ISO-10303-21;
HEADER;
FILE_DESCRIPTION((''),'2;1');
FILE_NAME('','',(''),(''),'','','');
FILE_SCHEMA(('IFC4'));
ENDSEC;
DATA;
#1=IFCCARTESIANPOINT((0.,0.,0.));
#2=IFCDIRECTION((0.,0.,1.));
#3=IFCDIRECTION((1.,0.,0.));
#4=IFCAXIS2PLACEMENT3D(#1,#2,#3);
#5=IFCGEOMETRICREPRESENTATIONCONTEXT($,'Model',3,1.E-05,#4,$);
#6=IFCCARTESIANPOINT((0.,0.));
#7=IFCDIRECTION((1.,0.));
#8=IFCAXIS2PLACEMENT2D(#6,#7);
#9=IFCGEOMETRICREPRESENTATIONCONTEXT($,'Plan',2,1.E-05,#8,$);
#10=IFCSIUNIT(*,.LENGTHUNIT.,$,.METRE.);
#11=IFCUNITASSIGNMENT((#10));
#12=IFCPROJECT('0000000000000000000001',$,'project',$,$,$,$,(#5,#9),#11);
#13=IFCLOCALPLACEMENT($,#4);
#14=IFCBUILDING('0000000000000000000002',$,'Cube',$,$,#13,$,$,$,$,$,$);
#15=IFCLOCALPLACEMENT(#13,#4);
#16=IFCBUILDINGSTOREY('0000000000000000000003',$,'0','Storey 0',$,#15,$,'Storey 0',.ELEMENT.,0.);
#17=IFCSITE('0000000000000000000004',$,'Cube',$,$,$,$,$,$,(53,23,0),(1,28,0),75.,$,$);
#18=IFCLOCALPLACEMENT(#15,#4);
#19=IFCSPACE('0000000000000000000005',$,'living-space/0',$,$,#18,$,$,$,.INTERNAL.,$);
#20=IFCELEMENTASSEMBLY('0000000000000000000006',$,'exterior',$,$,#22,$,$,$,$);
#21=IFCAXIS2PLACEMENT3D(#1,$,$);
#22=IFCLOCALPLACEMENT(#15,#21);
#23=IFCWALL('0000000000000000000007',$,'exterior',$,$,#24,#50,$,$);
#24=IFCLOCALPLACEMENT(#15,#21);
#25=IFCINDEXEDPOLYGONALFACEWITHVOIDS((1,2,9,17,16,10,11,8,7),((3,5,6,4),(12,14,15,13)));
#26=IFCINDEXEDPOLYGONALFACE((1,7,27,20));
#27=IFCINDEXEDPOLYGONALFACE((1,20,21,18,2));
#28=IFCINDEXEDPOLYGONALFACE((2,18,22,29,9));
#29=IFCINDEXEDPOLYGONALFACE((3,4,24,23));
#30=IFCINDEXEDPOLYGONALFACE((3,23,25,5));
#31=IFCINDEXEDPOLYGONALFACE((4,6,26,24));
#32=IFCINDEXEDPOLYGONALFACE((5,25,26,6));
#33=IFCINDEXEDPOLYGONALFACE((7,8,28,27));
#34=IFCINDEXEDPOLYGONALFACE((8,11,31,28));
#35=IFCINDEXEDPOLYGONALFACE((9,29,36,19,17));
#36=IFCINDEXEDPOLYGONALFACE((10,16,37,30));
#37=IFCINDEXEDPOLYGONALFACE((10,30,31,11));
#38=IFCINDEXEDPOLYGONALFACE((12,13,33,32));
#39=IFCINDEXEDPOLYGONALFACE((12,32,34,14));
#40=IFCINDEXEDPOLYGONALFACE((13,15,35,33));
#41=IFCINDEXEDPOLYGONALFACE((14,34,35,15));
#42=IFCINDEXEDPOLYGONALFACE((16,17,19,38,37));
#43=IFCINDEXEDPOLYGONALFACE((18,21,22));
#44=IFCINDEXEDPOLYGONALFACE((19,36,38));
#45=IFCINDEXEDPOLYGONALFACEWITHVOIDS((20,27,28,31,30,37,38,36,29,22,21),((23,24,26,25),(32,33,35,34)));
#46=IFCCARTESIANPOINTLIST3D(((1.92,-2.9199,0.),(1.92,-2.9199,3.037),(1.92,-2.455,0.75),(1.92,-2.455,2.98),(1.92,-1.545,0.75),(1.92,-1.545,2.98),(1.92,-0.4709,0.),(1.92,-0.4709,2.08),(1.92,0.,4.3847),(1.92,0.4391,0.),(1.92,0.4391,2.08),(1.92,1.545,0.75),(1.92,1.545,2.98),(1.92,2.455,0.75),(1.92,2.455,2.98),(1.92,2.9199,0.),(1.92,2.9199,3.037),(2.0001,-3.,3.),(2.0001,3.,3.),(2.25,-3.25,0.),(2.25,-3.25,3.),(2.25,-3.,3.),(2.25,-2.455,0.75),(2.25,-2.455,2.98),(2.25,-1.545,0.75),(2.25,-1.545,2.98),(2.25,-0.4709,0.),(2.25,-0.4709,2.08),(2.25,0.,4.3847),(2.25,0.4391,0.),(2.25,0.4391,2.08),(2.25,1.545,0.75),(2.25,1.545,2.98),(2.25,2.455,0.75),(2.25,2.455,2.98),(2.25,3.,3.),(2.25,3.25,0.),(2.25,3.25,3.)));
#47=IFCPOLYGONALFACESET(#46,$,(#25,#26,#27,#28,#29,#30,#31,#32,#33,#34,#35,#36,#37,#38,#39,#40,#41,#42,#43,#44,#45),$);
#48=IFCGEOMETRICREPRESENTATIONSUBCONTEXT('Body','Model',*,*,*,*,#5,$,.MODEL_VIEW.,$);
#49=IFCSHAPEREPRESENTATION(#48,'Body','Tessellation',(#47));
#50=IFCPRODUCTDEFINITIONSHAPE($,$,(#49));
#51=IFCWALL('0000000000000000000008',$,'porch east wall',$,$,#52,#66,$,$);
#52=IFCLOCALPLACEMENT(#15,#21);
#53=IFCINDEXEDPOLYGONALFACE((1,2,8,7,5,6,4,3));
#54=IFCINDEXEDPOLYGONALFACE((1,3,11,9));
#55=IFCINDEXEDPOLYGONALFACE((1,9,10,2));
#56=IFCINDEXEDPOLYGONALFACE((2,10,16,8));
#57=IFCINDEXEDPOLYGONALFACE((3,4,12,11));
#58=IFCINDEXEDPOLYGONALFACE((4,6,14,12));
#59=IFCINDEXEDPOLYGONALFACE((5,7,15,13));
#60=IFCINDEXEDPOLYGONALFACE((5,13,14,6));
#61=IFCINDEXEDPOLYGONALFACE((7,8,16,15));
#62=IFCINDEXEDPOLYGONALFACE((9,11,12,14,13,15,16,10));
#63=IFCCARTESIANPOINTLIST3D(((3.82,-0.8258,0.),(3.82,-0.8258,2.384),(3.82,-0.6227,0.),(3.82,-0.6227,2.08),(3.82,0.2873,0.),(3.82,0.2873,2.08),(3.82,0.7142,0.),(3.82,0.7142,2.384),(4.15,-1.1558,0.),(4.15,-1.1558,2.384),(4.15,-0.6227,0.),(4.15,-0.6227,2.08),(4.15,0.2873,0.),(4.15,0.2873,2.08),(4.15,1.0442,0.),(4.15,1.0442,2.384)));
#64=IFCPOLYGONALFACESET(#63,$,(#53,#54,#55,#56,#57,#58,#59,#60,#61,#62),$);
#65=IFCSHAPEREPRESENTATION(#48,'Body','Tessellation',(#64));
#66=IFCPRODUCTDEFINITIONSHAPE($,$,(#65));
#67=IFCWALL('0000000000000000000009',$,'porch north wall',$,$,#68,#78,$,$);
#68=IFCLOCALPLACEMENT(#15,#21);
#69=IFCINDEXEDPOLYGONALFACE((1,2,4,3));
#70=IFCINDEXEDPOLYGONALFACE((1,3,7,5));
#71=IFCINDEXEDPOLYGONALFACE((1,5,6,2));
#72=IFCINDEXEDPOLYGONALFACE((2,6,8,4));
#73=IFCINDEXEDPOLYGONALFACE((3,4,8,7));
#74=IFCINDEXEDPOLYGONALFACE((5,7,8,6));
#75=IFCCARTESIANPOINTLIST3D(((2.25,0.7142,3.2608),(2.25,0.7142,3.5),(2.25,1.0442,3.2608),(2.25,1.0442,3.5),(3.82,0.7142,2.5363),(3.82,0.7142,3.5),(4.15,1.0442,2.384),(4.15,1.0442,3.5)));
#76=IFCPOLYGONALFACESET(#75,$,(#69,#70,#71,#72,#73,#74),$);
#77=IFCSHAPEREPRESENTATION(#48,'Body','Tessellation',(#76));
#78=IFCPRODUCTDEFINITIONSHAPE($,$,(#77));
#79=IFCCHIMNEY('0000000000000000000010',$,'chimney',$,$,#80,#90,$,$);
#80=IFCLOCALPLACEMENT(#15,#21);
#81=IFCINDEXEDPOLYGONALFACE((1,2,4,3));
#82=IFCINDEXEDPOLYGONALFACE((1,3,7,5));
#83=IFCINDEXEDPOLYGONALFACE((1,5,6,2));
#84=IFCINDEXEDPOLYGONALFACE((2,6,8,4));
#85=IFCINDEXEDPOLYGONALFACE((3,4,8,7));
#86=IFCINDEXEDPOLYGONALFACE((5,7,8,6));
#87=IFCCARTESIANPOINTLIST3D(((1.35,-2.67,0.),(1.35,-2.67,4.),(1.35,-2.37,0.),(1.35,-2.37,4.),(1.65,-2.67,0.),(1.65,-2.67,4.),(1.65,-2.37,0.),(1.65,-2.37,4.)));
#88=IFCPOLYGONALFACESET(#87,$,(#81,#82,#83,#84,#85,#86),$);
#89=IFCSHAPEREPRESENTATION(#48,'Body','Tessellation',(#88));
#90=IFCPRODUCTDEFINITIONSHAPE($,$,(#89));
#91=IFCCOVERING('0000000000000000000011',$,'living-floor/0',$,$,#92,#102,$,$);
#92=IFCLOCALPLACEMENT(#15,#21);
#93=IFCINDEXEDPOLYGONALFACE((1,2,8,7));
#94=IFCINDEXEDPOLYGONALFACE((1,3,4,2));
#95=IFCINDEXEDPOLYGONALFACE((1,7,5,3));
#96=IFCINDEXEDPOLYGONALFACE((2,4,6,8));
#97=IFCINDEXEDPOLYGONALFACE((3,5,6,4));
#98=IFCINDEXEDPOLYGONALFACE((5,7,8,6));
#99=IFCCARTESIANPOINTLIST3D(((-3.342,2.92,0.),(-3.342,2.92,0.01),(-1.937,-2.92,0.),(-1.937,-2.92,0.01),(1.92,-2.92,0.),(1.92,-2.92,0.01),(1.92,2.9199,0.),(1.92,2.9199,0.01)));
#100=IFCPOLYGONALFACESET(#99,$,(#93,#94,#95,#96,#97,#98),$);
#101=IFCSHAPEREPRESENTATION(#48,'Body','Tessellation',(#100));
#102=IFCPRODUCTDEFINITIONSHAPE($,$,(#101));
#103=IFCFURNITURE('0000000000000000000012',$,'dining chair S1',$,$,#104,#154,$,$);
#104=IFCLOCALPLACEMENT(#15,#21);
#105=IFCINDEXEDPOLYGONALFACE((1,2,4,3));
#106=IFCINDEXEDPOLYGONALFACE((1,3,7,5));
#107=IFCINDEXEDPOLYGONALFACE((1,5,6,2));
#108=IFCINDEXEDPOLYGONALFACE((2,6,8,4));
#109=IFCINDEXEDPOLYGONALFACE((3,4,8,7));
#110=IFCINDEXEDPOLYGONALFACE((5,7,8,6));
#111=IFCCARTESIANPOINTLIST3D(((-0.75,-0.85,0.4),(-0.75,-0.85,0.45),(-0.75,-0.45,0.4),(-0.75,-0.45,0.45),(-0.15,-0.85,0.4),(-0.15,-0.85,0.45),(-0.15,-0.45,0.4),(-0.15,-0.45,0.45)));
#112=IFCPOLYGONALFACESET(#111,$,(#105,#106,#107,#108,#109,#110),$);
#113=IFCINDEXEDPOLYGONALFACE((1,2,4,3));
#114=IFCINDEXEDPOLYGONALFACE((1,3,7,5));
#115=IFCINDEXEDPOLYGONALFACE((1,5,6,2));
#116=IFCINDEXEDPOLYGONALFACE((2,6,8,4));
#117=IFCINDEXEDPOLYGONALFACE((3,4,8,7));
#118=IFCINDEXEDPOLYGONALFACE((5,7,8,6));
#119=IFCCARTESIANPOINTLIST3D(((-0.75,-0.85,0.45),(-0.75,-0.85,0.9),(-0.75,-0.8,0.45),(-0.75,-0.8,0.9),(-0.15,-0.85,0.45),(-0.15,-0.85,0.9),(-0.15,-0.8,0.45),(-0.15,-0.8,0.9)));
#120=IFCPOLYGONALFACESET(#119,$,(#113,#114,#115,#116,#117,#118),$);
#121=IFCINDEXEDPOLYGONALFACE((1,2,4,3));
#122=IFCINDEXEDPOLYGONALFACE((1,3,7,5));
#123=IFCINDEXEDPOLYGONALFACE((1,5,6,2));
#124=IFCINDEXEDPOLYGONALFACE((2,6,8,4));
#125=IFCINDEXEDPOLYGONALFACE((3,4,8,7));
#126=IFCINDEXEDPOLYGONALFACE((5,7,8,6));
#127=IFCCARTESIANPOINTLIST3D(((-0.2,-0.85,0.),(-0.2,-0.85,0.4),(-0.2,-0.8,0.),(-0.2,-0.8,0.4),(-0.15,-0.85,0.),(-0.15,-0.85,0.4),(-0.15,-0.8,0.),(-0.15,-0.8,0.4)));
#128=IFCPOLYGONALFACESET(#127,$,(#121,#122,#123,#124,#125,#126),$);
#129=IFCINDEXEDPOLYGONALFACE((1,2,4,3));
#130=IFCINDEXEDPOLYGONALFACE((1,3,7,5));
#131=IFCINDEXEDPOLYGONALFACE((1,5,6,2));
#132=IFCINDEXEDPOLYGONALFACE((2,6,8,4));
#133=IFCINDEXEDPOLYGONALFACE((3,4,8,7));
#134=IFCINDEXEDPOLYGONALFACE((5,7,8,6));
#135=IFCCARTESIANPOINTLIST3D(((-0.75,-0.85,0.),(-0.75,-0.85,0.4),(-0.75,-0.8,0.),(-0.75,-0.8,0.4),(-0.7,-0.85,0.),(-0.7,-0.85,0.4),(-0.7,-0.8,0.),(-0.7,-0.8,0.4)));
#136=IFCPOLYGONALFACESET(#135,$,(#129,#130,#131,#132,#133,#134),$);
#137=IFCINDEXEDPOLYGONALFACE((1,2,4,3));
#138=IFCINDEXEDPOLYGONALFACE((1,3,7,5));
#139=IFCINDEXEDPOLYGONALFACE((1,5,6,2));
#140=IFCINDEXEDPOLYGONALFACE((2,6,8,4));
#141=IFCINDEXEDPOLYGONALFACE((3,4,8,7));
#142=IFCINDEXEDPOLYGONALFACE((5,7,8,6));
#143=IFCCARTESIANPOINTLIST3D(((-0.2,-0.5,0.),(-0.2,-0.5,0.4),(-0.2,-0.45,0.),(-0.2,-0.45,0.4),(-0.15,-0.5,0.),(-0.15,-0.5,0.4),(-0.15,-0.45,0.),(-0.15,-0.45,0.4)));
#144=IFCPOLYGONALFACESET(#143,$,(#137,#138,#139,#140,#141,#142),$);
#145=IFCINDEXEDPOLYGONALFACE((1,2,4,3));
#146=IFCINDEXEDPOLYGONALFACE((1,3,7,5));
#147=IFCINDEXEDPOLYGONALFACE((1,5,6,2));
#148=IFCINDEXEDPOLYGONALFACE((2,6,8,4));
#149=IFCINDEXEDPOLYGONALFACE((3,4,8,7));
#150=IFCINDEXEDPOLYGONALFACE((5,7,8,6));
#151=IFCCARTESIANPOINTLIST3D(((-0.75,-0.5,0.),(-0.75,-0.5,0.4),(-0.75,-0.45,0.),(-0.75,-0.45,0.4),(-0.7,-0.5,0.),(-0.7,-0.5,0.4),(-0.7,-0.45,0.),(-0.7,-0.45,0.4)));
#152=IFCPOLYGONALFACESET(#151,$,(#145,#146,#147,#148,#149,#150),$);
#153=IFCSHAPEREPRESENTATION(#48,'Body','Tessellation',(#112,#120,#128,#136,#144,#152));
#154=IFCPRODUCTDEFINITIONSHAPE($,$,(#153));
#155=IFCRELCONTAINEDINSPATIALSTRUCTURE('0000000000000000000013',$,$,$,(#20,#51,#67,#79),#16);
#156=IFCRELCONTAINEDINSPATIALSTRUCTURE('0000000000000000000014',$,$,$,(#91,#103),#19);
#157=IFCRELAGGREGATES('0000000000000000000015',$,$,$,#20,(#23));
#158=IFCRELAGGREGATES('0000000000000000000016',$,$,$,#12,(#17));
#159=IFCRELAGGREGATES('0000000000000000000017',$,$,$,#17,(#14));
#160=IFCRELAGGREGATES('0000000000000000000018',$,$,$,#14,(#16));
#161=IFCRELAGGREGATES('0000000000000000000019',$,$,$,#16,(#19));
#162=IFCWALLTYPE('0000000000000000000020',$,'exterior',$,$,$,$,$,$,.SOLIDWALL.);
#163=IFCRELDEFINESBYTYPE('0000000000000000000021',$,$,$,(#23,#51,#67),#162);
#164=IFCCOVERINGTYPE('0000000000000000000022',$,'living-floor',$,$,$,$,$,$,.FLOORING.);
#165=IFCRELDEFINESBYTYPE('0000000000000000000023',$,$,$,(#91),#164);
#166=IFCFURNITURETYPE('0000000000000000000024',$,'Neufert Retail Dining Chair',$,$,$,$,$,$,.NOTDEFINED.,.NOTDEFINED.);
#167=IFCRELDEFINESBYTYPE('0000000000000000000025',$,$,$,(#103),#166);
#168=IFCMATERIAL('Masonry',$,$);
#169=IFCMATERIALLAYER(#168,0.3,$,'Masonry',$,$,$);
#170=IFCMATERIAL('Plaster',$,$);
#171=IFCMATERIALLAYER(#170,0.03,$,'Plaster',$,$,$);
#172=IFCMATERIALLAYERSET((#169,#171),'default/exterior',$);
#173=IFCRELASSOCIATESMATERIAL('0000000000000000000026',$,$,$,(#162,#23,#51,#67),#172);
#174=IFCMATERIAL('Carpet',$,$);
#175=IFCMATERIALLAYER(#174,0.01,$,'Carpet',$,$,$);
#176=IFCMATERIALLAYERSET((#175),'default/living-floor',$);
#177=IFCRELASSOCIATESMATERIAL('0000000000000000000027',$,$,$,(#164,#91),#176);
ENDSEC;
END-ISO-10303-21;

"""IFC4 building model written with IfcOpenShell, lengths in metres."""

from ifc_helpers import new_model, entity, si_unit, frame, origin, origin_with_axes, origin_2d_with_axis, place, context, subcontext, project, spatial, polyline, line, indexed_curve, outline, extrude, clip, halfspace, bounded_halfspace, shape, source, transform, mapped, material, layer, layer_set, layer_usage, type_object, type_shapes, element, aggregate, save


model = new_model("IFC4")

# Units and contexts
model_context = context("Model", 3, precision=1e-05, world=origin_with_axes())
plan_context = context("Plan", 2, precision=1e-05, world=origin_2d_with_axis())
body_context_1 = subcontext(model_context, "Body", "Model", "MODEL_VIEW")
body_context_2 = subcontext(plan_context, "Body", "Plan", "PLAN_VIEW")
ifc_project = project(units=[si_unit("LENGTHUNIT", "METRE")], contexts=[model_context, plan_context])

# Site, building, storey
site = spatial("IfcSite", under=ifc_project, Name="Cube", RefLatitude=(53, 23, 0), RefLongitude=(1, 28, 0), RefElevation=75.0)
building_placement = place(None, origin_with_axes())
building = spatial("IfcBuilding", under=site, at=building_placement, Name="Cube")
storey_placement = place(building_placement, origin_with_axes())
storey = spatial("IfcBuildingStorey", under=building, at=storey_placement, Name="0", Description="Storey 0", LongName="Storey 0", CompositionType="ELEMENT", Elevation=0.0)

# Element assembly, wall, openings
ifc_material_1 = material(Name="Masonry")
ifc_layer_1 = layer(ifc_material_1, 0.3, Name="Masonry")
ifc_material_2 = material(Name="Plaster")
ifc_layer_2 = layer(ifc_material_2, 0.03, Name="Plaster")
ifc_layer_set_1 = layer_set([ifc_layer_1, ifc_layer_2], Name="default/exterior")
wall_type = type_object("IfcWallType", Name="exterior", PredefinedType="SOLIDWALL", material=ifc_layer_set_1)
assembly_1_placement = place(storey_placement, frame((2.0, -3.0, 0.0), z_axis=(0.0, 0.0, 1.0), x_axis=(0.0, 1.0, 0.0)))
assembly_1 = element("IfcElementAssembly", 1, at=assembly_1_placement, inside=storey, Name="exterior")
ifc_layer_usage_1 = layer_usage(ifc_layer_set_1, "AXIS2", "POSITIVE", -0.25)
wall_1_placement = place(assembly_1_placement, origin_with_axes())
wall_1 = element("IfcWall", 2, at=wall_1_placement, type_object=wall_type, material=ifc_layer_usage_1, Name="exterior", context=body_context_1, shape_type="Clipping", body=[
    clip(clip(clip(clip(extrude(outline(polyline([(0.0801, 0.08), (-0.25, -0.25), (6.25, -0.25), (5.9199, 0.08), (0.0801, 0.08)])), origin(), (0.0, 0.0, 1.0), 4.385), bounded_halfspace(frame((6.0, 0.0, 3.0), z_axis=(0.419069, 0.0, 0.907954), x_axis=(0.0, -1.0, 0.0)), False, origin(), polyline([(6.0, -1.0), (3.0, -1.0), (3.0, 1.0), (6.0, 1.0), (6.0, -1.0)]))), bounded_halfspace(frame((6.0, 0.0, 3.0), z_axis=(0.0, 0.0, 1.0), x_axis=(0.0, 1.0, 0.0)), False, origin(), polyline([(6.0, 1.0), (7.0, 1.0), (7.0, -1.0), (6.0, -1.0), (6.0, 1.0)]))), bounded_halfspace(frame((3.0, 0.0, 4.3847), z_axis=(-0.419069, 0.0, 0.907954), x_axis=(0.0, -1.0, 0.0)), False, origin(), polyline([(3.0, -1.0), (0.0, -1.0), (0.0, 1.0), (3.0, 1.0), (3.0, -1.0)]))), bounded_halfspace(frame((0.0, 0.0, 3.0), z_axis=(0.0, 0.0, 1.0), x_axis=(0.0, -1.0, 0.0)), False, origin(), polyline([(0.0, -1.0), (-1.0, -1.0), (-1.0, 1.0), (0.0, 1.0), (0.0, -1.0)]))),
])
opening_1_placement = place(wall_1_placement, frame((0.545, -0.25, 0.75), z_axis=(0.0, 0.0, 1.0), x_axis=(1.0, 0.0, 0.0)))
element("IfcOpeningElement", 3, at=opening_1_placement, cuts=wall_1, PredefinedType="OPENING", context=body_context_1, shape_type="SweptSolid", body=[
    extrude(outline(polyline([(0.0, -0.02), (0.91, -0.02), (0.91, 0.35), (0.0, 0.35), (0.0, -0.02)])), origin(), (0.0, 0.0, 1.0), 2.23),
])
opening_2_placement = place(wall_1_placement, frame((4.545, -0.25, 0.75), z_axis=(0.0, 0.0, 1.0), x_axis=(1.0, 0.0, 0.0)))
element("IfcOpeningElement", 4, at=opening_2_placement, cuts=wall_1, PredefinedType="OPENING", context=body_context_1, shape_type="SweptSolid", body=[
    extrude(outline(polyline([(0.0, -0.02), (0.91, -0.02), (0.91, 0.35), (0.0, 0.35), (0.0, -0.02)])), origin(), (0.0, 0.0, 1.0), 2.23),
])
shared_shape_1 = source(origin_with_axes(), body_context_1, "Body", "SweptSolid", [
    extrude(outline(indexed_curve([(0.0, 0.0), (0.91, 0.0), (0.91, 2.08), (0.0, 2.08)], segments=[line(1, 2, 3, 4, 1)])), frame((0.0, -0.6, 0.0), z_axis=(0.0, -1.0, 0.0), x_axis=(1.0, 0.0, 0.0)), (0.0, 0.0, -1.0), 1.2),
])
opening_3_placement = place(wall_1_placement, frame((2.5291, -0.25, 0.0), z_axis=(0.0, 0.0, 1.0), x_axis=(1.0, 0.0, 0.0)))
element("IfcOpeningElement", 5, at=opening_3_placement, cuts=wall_1, PredefinedType="OPENING", context=body_context_1, shape_type="MappedRepresentation", body=[
    mapped(shared_shape_1, transform((0.0, 0.0, 0.0), x_axis=(1.0, 0.0, 0.0), y_axis=(0.0, 1.0, 0.0), z_axis=(0.0, 0.0, 1.0), scale=1.0)),
])
aggregate(assembly_1, [wall_1])

# Wall, opening
ifc_layer_usage_2 = layer_usage(ifc_layer_set_1, "AXIS2", "POSITIVE", 0.0)
wall_2_placement = place(storey_placement, frame((4.15, -1.1558, 0.0), z_axis=(0.0, 0.0, 1.0), x_axis=(0.0, 1.0, 0.0)))
wall_2 = element("IfcWall", 6, at=wall_2_placement, inside=storey, type_object=wall_type, material=ifc_layer_usage_2, Name="porch east wall", context=body_context_1, shape_type="SweptSolid", body=[
    extrude(outline(indexed_curve([(0.0, 0.0), (0.33, 0.33), (1.87, 0.33), (2.2, 0.0)], segments=[line(1, 2, 3, 4, 1)])), origin_with_axes(), (0.0, 0.0, 1.0), 2.384),
])
shared_shape_2 = source(origin_with_axes(), body_context_1, "Body", "SweptSolid", [
    extrude(outline(indexed_curve([(0.0, 0.0), (0.91, 0.0), (0.91, 2.08), (0.0, 2.08)], segments=[line(1, 2, 3, 4, 1)])), frame((0.0, -0.6, 0.0), z_axis=(0.0, -1.0, 0.0), x_axis=(1.0, 0.0, 0.0)), (0.0, 0.0, -1.0), 1.2),
])
opening_4_placement = place(wall_2_placement, frame((0.5331, 0.0, 0.0), z_axis=(0.0, 0.0, 1.0), x_axis=(1.0, 0.0, 0.0)))
element("IfcOpeningElement", 7, at=opening_4_placement, cuts=wall_2, PredefinedType="OPENING", context=body_context_1, shape_type="MappedRepresentation", body=[
    mapped(shared_shape_2, transform((0.0, 0.0, 0.0), x_axis=(1.0, 0.0, 0.0), y_axis=(0.0, 1.0, 0.0), z_axis=(0.0, 0.0, 1.0), scale=1.0)),
])

# Wall
ifc_layer_usage_3 = layer_usage(ifc_layer_set_1, "AXIS2", "POSITIVE", 0.0)
wall_3_placement = place(storey_placement, frame((4.15, 1.0442, 0.0), z_axis=(0.0, 0.0, 1.0), x_axis=(-1.0, 0.0, 0.0)))
element("IfcWall", 8, at=wall_3_placement, inside=storey, type_object=wall_type, material=ifc_layer_usage_3, Name="porch north wall", context=body_context_1, shape_type="Clipping", body=[
    clip(extrude(outline(indexed_curve([(0.0, 0.0), (1.9, 0.0), (1.9, 0.33), (0.33, 0.33)], segments=[line(1, 2, 3, 4, 1)])), origin_with_axes(), (0.0, 0.0, 1.0), 3.5), halfspace(frame((0.0, 0.0, 2.384), z_axis=(0.419, 0.0, -0.908), x_axis=(0.0, -1.0, 0.0)), False)),
])

# Chimney
chimney_placement = place(storey_placement, frame((1.35, -2.67, 0.0), z_axis=(0.0, 0.0, 1.0), x_axis=(1.0, 0.0, 0.0)))
element("IfcChimney", 9, at=chimney_placement, inside=storey, Name="chimney", context=body_context_1, shape_type="SweptSolid", body=[
    extrude(outline(indexed_curve([(0.0, 0.0), (0.3, 0.0), (0.3, 0.3), (0.0, 0.3)])), None, (0.0, 0.0, 1.0), 4.0),
])

# Shared definitions
space_placement = place(storey_placement, origin_with_axes())
space = spatial("IfcSpace", under=storey, at=space_placement, Name="living-space/0", PredefinedType="INTERNAL")

# Covering
ifc_material_3 = material(Name="Carpet")
ifc_layer_3 = layer(ifc_material_3, 0.01, Name="Carpet")
ifc_layer_set_2 = layer_set([ifc_layer_3], Name="default/living-floor")
ifc_layer_usage_4 = layer_usage(ifc_layer_set_2, "AXIS3", "POSITIVE", 0.0)
covering_type = type_object("IfcCoveringType", Name="living-floor", PredefinedType="FLOORING", material=ifc_layer_set_2)
covering_placement = place(space_placement, origin_with_axes())
element("IfcCovering", 10, at=covering_placement, inside=space, type_object=covering_type, material=ifc_layer_usage_4, Name="living-floor/0", context=body_context_1, shape_type="SweptSolid", body=[
    extrude(outline(polyline([(1.92, 2.9199), (-3.342, 2.92), (-1.937, -2.92), (1.92, -2.92), (1.92, 2.9199)])), origin_with_axes(), (0.0, 0.0, 1.0), 0.01),
])

# Furniture
furniture_type_1 = type_object("IfcFurnitureType", Name="Neufert Retail Dining Chair", AssemblyPlace="NOTDEFINED", PredefinedType="NOTDEFINED")
shared_shape_3 = source(origin_with_axes(), body_context_1, "Body", "SweptSolid", [
    extrude(outline(indexed_curve([(-0.3, 0.0), (0.3, 0.0), (0.3, -0.4), (-0.3, -0.4)], segments=[line(1, 2, 3, 4, 1)])), frame((0.0, 0.0, 0.45), z_axis=(0.0, 0.0, 1.0), x_axis=(1.0, 0.0, 0.0)), (0.0, 0.0, -1.0), 0.05),
    extrude(outline(indexed_curve([(-0.3, 0.0), (0.3, 0.0), (0.3, -0.05), (-0.3, -0.05)], segments=[line(1, 2, 3, 4, 1)])), frame((0.0, 0.0, 0.9), z_axis=(0.0, 0.0, 1.0), x_axis=(1.0, 0.0, 0.0)), (0.0, 0.0, -1.0), 0.45),
    extrude(outline(indexed_curve([(-0.3, 0.0), (-0.25, 0.0), (-0.25, -0.05), (-0.3, -0.05)], segments=[line(1, 2, 3, 4, 1)])), origin_with_axes(), (0.0, 0.0, 1.0), 0.4),
    extrude(outline(indexed_curve([(0.3, 0.0), (0.25, 0.0), (0.25, -0.05), (0.3, -0.05)], segments=[line(1, 2, 3, 4, 1)])), origin_with_axes(), (0.0, 0.0, 1.0), 0.4),
    extrude(outline(indexed_curve([(-0.3, -0.4), (-0.25, -0.4), (-0.25, -0.35), (-0.3, -0.35)], segments=[line(1, 2, 3, 4, 1)])), origin_with_axes(), (0.0, 0.0, 1.0), 0.4),
    extrude(outline(indexed_curve([(0.3, -0.4), (0.25, -0.4), (0.25, -0.35), (0.3, -0.35)], segments=[line(1, 2, 3, 4, 1)])), origin_with_axes(), (0.0, 0.0, 1.0), 0.4),
])
shared_shape_4 = source(origin_with_axes(), body_context_2, "Body", "Curve2D", [
    entity("IfcIndexedPolyCurve", entity("IfcCartesianPointList2D", [[-0.3, -0.4], [0.3, -0.4]])),
    entity("IfcIndexedPolyCurve", entity("IfcCartesianPointList2D", [[-0.3, -0.4], [-0.3, -0.3], [-0.2121, -0.0879], [0.0, 0.0], [0.2121, -0.0879], [0.3, -0.3], [0.3, -0.4]]), [entity("IfcLineIndex", [1, 2]), entity("IfcArcIndex", [2, 3, 4]), entity("IfcArcIndex", [4, 5, 6]), entity("IfcLineIndex", [6, 7])]),
    entity("IfcIndexedPolyCurve", entity("IfcCartesianPointList2D", [[-0.26, -0.4], [-0.26, -0.3], [-0.1838, -0.1162], [0.0, -0.04], [0.1838, -0.1162], [0.26, -0.3], [0.26, -0.4]]), [entity("IfcLineIndex", [1, 2]), entity("IfcArcIndex", [2, 3, 4]), entity("IfcArcIndex", [4, 5, 6]), entity("IfcLineIndex", [6, 7])]),
])
type_shapes(furniture_type_1, [shared_shape_3, shared_shape_4])
for number, where, z_axis, x_axis, name in (
    (11, (-0.45, -0.85, 0.0), (0.0, 0.0, 1.0), (-1.0, 0.0, 0.0), "dining chair S1"),
):
    element("IfcFurniture", number, at=place(space_placement, frame(where, z_axis=z_axis, x_axis=x_axis)), inside=space, type_object=furniture_type_1, Name=name, shapes=[
        shape(body_context_1, "Body", "MappedRepresentation", [mapped(shared_shape_3, transform((0.0, 0.0, 0.0), x_axis=(1.0, 0.0, 0.0), y_axis=(0.0, 1.0, 0.0), z_axis=(0.0, 0.0, 1.0), scale=1.0))]),
        shape(body_context_2, "Body", "MappedRepresentation", [mapped(shared_shape_4, transform((0.0, 0.0, 0.0), x_axis=(1.0, 0.0, 0.0), y_axis=(0.0, 1.0, 0.0), z_axis=(0.0, 0.0, 1.0), scale=1.0))]),
    ])

save(model, "model.ifc")
